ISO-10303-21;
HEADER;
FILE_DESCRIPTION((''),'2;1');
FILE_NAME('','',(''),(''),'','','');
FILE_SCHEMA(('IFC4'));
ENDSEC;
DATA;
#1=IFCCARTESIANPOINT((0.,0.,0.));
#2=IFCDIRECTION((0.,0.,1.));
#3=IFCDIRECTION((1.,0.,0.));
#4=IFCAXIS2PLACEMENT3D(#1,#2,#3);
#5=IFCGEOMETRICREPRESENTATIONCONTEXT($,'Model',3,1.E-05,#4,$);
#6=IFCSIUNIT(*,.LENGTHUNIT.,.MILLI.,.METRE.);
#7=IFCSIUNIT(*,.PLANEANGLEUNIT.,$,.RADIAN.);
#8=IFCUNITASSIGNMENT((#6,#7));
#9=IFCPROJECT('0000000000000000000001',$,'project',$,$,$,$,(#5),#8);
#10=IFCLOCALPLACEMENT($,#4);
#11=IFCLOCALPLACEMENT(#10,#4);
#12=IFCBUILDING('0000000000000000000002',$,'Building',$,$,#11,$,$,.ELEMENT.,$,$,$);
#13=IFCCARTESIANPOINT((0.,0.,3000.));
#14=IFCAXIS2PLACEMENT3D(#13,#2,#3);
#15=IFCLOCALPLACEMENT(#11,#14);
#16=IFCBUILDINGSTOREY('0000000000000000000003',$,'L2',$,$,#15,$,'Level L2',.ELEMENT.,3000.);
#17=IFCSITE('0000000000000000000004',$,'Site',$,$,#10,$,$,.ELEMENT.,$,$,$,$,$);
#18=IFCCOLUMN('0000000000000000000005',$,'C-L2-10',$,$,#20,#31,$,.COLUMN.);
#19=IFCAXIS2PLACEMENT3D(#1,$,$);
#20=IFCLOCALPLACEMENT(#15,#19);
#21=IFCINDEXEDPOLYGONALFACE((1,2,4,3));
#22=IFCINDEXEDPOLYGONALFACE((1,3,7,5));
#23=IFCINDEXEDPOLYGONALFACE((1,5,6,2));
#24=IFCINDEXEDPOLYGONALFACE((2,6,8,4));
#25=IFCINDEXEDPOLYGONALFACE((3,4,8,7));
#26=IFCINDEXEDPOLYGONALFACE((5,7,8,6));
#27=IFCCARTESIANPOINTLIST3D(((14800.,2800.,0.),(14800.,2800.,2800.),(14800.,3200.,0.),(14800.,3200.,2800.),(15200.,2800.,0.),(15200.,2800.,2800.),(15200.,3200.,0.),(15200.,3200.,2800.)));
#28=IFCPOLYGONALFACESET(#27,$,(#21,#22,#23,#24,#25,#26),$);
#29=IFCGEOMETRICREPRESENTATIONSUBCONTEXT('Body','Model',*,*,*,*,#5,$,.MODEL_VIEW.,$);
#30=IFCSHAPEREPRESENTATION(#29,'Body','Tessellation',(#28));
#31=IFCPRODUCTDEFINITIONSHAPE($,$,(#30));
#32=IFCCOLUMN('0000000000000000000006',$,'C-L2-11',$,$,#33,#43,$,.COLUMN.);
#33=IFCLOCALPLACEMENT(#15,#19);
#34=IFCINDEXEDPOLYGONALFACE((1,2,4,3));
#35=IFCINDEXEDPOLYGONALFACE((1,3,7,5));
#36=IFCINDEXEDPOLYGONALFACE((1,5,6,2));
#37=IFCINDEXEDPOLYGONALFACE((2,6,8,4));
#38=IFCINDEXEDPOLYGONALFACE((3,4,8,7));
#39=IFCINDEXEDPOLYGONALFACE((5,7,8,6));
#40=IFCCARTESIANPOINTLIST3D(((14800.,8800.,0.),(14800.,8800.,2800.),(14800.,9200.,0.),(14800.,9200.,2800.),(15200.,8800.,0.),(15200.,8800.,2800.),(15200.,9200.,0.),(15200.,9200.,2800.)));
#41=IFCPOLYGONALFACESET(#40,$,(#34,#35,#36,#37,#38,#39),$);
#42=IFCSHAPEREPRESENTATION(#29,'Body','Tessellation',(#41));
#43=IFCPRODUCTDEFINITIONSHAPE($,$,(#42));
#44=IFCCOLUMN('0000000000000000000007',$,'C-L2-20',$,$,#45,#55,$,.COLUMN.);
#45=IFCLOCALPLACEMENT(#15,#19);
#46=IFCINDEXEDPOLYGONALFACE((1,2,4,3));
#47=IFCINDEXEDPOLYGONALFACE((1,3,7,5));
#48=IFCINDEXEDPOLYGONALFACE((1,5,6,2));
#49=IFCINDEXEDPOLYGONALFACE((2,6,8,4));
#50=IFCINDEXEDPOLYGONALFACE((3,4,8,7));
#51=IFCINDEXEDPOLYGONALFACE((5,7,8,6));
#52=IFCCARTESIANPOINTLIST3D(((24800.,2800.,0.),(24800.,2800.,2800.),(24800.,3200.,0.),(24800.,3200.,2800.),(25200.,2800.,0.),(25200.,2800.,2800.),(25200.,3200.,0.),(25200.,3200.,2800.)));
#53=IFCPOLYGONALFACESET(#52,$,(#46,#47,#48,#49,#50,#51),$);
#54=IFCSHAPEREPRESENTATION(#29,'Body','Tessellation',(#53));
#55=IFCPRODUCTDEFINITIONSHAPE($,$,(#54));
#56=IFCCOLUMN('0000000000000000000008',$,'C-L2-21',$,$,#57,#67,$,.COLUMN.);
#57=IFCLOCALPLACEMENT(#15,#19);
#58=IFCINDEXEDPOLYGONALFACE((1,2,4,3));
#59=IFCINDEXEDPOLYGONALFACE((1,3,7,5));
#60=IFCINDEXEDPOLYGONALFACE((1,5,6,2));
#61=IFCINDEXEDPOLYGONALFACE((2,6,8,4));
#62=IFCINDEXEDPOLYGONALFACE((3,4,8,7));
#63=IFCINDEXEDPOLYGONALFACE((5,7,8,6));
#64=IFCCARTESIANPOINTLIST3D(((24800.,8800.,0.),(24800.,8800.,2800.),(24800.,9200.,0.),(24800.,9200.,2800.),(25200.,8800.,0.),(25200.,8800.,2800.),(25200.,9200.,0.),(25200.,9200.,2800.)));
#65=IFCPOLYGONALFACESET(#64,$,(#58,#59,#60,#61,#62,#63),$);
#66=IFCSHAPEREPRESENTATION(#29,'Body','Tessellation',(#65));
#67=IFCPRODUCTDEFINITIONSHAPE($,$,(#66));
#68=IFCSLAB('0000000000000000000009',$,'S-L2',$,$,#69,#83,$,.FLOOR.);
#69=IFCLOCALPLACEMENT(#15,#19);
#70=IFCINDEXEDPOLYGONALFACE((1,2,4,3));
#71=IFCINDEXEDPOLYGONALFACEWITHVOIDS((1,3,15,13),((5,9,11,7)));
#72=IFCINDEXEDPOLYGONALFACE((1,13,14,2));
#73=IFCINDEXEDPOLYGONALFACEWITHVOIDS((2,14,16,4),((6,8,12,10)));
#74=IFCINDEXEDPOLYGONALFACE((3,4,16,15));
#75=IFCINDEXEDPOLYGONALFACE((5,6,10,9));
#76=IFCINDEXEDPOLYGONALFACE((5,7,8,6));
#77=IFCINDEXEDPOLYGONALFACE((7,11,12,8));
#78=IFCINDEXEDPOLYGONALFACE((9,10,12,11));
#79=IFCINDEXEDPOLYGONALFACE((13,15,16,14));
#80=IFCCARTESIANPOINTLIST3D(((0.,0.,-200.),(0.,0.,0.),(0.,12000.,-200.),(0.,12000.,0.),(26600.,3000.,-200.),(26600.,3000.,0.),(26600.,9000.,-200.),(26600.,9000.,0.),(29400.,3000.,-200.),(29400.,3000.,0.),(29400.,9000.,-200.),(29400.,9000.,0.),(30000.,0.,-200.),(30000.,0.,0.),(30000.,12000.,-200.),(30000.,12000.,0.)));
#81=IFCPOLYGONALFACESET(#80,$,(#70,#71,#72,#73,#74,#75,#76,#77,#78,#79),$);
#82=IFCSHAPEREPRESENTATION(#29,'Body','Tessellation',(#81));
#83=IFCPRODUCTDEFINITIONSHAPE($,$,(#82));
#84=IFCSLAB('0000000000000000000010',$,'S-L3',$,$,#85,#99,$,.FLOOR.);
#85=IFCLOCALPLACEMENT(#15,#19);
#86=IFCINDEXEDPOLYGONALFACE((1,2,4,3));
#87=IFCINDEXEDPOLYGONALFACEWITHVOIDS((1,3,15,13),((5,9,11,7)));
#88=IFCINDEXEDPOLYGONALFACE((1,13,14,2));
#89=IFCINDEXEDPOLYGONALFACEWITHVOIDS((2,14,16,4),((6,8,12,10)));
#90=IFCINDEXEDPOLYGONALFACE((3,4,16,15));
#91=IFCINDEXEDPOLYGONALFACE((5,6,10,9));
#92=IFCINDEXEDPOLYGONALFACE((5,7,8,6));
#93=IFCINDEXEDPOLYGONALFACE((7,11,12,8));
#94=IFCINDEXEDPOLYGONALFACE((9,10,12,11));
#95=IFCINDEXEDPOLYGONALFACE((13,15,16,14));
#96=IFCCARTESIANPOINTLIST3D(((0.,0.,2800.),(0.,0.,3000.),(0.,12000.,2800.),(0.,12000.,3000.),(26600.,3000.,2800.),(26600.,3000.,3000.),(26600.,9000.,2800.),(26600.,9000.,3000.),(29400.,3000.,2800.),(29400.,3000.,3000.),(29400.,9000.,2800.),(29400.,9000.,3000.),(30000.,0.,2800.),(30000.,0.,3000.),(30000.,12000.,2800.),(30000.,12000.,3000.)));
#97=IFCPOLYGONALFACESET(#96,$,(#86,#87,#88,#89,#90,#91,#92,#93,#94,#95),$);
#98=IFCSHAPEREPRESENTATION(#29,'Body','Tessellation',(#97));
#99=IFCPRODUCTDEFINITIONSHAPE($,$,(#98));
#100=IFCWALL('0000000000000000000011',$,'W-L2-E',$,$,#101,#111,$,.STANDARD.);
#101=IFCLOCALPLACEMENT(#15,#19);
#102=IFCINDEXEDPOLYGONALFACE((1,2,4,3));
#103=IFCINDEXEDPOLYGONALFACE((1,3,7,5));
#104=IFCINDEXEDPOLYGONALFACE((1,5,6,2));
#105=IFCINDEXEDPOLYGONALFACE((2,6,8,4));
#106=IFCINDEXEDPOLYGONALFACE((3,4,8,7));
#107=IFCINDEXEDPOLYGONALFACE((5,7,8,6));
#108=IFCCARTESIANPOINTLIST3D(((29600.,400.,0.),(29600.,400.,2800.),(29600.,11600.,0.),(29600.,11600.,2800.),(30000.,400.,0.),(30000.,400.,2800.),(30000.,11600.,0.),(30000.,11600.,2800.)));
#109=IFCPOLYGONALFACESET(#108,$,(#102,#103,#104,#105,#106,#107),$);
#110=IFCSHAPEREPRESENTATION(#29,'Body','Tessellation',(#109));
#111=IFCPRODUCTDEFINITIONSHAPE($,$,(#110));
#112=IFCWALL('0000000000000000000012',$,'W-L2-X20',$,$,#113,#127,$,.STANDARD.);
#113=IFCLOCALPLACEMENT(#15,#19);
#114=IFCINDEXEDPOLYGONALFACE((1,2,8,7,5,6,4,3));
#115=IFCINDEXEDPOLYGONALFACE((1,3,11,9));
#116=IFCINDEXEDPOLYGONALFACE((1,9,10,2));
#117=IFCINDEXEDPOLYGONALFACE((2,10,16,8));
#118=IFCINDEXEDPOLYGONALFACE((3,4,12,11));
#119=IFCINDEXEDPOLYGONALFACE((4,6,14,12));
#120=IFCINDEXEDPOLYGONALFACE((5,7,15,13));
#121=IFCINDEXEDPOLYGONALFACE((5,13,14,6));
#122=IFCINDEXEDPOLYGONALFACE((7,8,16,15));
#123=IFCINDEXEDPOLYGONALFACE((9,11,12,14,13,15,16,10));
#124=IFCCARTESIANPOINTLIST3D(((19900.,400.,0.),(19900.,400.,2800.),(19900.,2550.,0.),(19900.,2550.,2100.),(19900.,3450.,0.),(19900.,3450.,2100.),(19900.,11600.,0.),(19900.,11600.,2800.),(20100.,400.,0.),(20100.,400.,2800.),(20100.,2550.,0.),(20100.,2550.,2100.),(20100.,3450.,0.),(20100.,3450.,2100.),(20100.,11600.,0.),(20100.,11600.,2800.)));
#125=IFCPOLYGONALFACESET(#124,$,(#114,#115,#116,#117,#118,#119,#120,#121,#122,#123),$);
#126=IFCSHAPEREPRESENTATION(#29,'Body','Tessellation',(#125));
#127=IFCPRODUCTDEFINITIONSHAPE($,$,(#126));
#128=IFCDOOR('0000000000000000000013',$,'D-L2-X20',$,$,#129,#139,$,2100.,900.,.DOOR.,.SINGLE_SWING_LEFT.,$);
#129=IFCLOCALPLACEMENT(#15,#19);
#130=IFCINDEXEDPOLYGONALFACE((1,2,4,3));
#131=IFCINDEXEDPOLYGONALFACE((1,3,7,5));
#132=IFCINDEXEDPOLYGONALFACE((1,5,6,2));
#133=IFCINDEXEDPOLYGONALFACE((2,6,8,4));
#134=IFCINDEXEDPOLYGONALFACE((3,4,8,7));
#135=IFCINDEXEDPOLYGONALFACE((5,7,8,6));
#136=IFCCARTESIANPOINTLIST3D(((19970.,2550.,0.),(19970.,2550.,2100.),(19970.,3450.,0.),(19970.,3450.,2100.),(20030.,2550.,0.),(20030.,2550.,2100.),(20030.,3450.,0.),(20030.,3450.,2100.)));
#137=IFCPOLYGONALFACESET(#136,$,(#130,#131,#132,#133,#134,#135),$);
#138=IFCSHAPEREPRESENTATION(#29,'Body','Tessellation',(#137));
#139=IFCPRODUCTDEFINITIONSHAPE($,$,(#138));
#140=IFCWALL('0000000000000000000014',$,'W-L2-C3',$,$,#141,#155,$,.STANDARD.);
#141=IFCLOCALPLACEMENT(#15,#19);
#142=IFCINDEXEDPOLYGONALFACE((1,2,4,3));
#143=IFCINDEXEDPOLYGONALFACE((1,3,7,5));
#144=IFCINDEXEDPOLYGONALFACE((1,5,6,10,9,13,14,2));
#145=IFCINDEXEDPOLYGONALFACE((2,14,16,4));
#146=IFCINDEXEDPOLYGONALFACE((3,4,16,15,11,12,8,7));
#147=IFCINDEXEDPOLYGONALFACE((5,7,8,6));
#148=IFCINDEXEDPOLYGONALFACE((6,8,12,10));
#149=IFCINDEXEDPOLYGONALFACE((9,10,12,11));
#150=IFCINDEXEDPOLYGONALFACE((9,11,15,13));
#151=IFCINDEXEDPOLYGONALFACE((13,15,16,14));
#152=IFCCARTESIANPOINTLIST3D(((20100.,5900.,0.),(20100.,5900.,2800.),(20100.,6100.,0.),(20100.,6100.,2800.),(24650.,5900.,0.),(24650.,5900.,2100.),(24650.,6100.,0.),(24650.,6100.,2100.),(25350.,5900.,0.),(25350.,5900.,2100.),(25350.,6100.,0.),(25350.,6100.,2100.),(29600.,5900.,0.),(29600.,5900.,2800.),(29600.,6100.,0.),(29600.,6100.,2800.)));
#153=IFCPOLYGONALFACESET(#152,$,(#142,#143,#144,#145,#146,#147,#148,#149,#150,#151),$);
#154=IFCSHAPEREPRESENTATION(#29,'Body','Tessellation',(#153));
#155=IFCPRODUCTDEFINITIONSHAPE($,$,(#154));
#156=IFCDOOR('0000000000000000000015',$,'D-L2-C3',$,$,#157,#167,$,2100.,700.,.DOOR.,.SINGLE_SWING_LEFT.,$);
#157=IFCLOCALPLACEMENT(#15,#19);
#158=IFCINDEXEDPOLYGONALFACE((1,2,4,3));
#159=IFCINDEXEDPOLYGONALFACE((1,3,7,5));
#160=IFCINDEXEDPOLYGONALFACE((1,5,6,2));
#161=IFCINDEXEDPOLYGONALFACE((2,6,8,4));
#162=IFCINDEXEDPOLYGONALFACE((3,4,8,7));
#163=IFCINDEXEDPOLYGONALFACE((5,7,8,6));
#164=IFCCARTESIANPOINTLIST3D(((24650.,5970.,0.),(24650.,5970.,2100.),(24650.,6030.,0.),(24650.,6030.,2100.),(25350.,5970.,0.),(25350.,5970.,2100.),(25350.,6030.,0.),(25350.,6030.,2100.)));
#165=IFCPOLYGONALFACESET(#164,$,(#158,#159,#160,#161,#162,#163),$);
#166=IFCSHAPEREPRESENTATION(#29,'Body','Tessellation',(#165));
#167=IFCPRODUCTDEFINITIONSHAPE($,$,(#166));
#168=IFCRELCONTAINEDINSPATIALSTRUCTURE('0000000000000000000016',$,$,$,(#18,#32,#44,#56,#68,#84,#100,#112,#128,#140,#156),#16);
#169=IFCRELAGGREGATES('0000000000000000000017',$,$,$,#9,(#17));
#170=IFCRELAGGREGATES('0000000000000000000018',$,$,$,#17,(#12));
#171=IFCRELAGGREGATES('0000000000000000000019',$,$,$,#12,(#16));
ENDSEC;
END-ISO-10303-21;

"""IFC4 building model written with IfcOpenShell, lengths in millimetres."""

from ifc_helpers import new_model, si_unit, frame, origin_with_axes, origin_2d, place, context, subcontext, project, spatial, rectangle, extrude, element, fill, save


model = new_model("IFC4")

# Units and contexts
model_context = context("Model", 3, precision=1e-05, world=origin_with_axes())
body_context = subcontext(model_context, "Body", "Model", "MODEL_VIEW")
ifc_project = project(units=[si_unit("LENGTHUNIT", "METRE", prefix="MILLI"), si_unit("PLANEANGLEUNIT", "RADIAN")], contexts=[model_context])

# Site, building, storey
site_placement = place(None, origin_with_axes())
site = spatial("IfcSite", under=ifc_project, at=site_placement, Name="Site", CompositionType="ELEMENT")
building_placement = place(site_placement, origin_with_axes())
building = spatial("IfcBuilding", under=site, at=building_placement, Name="Building", CompositionType="ELEMENT")
storey_placement = place(building_placement, frame((0.0, 0.0, 3000.0), z_axis=(0.0, 0.0, 1.0), x_axis=(1.0, 0.0, 0.0)))
storey = spatial("IfcBuildingStorey", under=building, at=storey_placement, Name="L2", LongName="Level L2", CompositionType="ELEMENT", Elevation=3000.0)

# Columns
for number, where, z_axis, x_axis, name in (
    (1, (15000.0, 3000.0, 0.0), (0.0, 0.0, 1.0), (1.0, 0.0, 0.0), "C-L2-10"),
    (2, (15000.0, 9000.0, 0.0), (0.0, 0.0, 1.0), (1.0, 0.0, 0.0), "C-L2-11"),
    (3, (25000.0, 3000.0, 0.0), (0.0, 0.0, 1.0), (1.0, 0.0, 0.0), "C-L2-20"),
    (4, (25000.0, 9000.0, 0.0), (0.0, 0.0, 1.0), (1.0, 0.0, 0.0), "C-L2-21"),
):
    element("IfcColumn", number, at=place(storey_placement, frame(where, z_axis=z_axis, x_axis=x_axis)), inside=storey, Name=name, PredefinedType="COLUMN", context=body_context, shape_type="SweptSolid", body=[
        extrude(rectangle(XDim=400.0, YDim=400.0, at=origin_2d()), origin_with_axes(), (0.0, 0.0, 1.0), 2800.0),
    ])

# Slabs, openings
slab_1_placement = place(storey_placement, frame((15000.0, 6000.0, -200.0), z_axis=(0.0, 0.0, 1.0), x_axis=(1.0, 0.0, 0.0)))
slab_1 = element("IfcSlab", 5, at=slab_1_placement, inside=storey, Name="S-L2", PredefinedType="FLOOR", context=body_context, shape_type="SweptSolid", body=[
    extrude(rectangle(XDim=30000.0, YDim=12000.0, at=origin_2d()), origin_with_axes(), (0.0, 0.0, 1.0), 200.0),
])
opening_1_placement = place(slab_1_placement, frame((13000.0, 0.0, -50.0), z_axis=(0.0, 0.0, 1.0), x_axis=(1.0, 0.0, 0.0)))
element("IfcOpeningElement", 6, at=opening_1_placement, cuts=slab_1, PredefinedType="OPENING", context=body_context, shape_type="SweptSolid", body=[
    extrude(rectangle(XDim=2800.0, YDim=6000.0, at=origin_2d()), origin_with_axes(), (0.0, 0.0, 1.0), 300.0),
])
placement = place(building_placement, frame((0.0, 0.0, 6000.0), z_axis=(0.0, 0.0, 1.0), x_axis=(1.0, 0.0, 0.0)))
slab_2_placement = place(placement, frame((15000.0, 6000.0, -200.0), z_axis=(0.0, 0.0, 1.0), x_axis=(1.0, 0.0, 0.0)))
slab_2 = element("IfcSlab", 7, at=slab_2_placement, inside=storey, Name="S-L3", PredefinedType="FLOOR", context=body_context, shape_type="SweptSolid", body=[
    extrude(rectangle(XDim=30000.0, YDim=12000.0, at=origin_2d()), origin_with_axes(), (0.0, 0.0, 1.0), 200.0),
])
opening_2_placement = place(slab_2_placement, frame((13000.0, 0.0, -50.0), z_axis=(0.0, 0.0, 1.0), x_axis=(1.0, 0.0, 0.0)))
element("IfcOpeningElement", 8, at=opening_2_placement, cuts=slab_2, PredefinedType="OPENING", context=body_context, shape_type="SweptSolid", body=[
    extrude(rectangle(XDim=2800.0, YDim=6000.0, at=origin_2d()), origin_with_axes(), (0.0, 0.0, 1.0), 300.0),
])

# Wall
wall_1_placement = place(storey_placement, frame((29800.0, 6000.0, 0.0), z_axis=(0.0, 0.0, 1.0), x_axis=(1.0, 0.0, 0.0)))
element("IfcWall", 9, at=wall_1_placement, inside=storey, Name="W-L2-E", PredefinedType="STANDARD", context=body_context, shape_type="SweptSolid", body=[
    extrude(rectangle(XDim=400.0, YDim=11200.0, at=origin_2d()), origin_with_axes(), (0.0, 0.0, 1.0), 2800.0),
])

# Walls, openings, doors
wall_2_placement = place(storey_placement, frame((20000.0, 6000.0, 0.0), z_axis=(0.0, 0.0, 1.0), x_axis=(1.0, 0.0, 0.0)))
wall_2 = element("IfcWall", 10, at=wall_2_placement, inside=storey, Name="W-L2-X20", PredefinedType="STANDARD", context=body_context, shape_type="SweptSolid", body=[
    extrude(rectangle(XDim=200.0, YDim=11200.0, at=origin_2d()), origin_with_axes(), (0.0, 0.0, 1.0), 2800.0),
])
opening_3_placement = place(wall_2_placement, frame((0.0, -3000.0, 0.0), z_axis=(0.0, 0.0, 1.0), x_axis=(1.0, 0.0, 0.0)))
opening_3 = element("IfcOpeningElement", 11, at=opening_3_placement, cuts=wall_2, PredefinedType="OPENING", context=body_context, shape_type="SweptSolid", body=[
    extrude(rectangle(XDim=300.0, YDim=900.0, at=origin_2d()), origin_with_axes(), (0.0, 0.0, 1.0), 2100.0),
])
door_1_placement = place(wall_2_placement, frame((0.0, -3000.0, 0.0), z_axis=(0.0, 0.0, 1.0), x_axis=(1.0, 0.0, 0.0)))
door_1 = element("IfcDoor", 12, at=door_1_placement, inside=storey, Name="D-L2-X20", OperationType="SINGLE_SWING_LEFT", OverallHeight=2100.0, OverallWidth=900.0, PredefinedType="DOOR", context=body_context, shape_type="SweptSolid", body=[
    extrude(rectangle(XDim=60.0, YDim=900.0, at=origin_2d()), origin_with_axes(), (0.0, 0.0, 1.0), 2100.0),
])
fill(opening_3, door_1)
wall_3_placement = place(storey_placement, frame((24850.0, 6000.0, 0.0), z_axis=(0.0, 0.0, 1.0), x_axis=(1.0, 0.0, 0.0)))
wall_3 = element("IfcWall", 13, at=wall_3_placement, inside=storey, Name="W-L2-C3", PredefinedType="STANDARD", context=body_context, shape_type="SweptSolid", body=[
    extrude(rectangle(XDim=9500.0, YDim=200.0, at=origin_2d()), origin_with_axes(), (0.0, 0.0, 1.0), 2800.0),
])
opening_4_placement = place(wall_3_placement, frame((150.0, 0.0, 0.0), z_axis=(0.0, 0.0, 1.0), x_axis=(1.0, 0.0, 0.0)))
opening_4 = element("IfcOpeningElement", 14, at=opening_4_placement, cuts=wall_3, PredefinedType="OPENING", context=body_context, shape_type="SweptSolid", body=[
    extrude(rectangle(XDim=700.0, YDim=300.0, at=origin_2d()), origin_with_axes(), (0.0, 0.0, 1.0), 2100.0),
])
door_2_placement = place(wall_3_placement, frame((150.0, 0.0, 0.0), z_axis=(0.0, 0.0, 1.0), x_axis=(1.0, 0.0, 0.0)))
door_2 = element("IfcDoor", 15, at=door_2_placement, inside=storey, Name="D-L2-C3", OperationType="SINGLE_SWING_LEFT", OverallHeight=2100.0, OverallWidth=700.0, PredefinedType="DOOR", context=body_context, shape_type="SweptSolid", body=[
    extrude(rectangle(XDim=700.0, YDim=60.0, at=origin_2d()), origin_with_axes(), (0.0, 0.0, 1.0), 2100.0),
])
fill(opening_4, door_2)

save(model, "model.ifc")
